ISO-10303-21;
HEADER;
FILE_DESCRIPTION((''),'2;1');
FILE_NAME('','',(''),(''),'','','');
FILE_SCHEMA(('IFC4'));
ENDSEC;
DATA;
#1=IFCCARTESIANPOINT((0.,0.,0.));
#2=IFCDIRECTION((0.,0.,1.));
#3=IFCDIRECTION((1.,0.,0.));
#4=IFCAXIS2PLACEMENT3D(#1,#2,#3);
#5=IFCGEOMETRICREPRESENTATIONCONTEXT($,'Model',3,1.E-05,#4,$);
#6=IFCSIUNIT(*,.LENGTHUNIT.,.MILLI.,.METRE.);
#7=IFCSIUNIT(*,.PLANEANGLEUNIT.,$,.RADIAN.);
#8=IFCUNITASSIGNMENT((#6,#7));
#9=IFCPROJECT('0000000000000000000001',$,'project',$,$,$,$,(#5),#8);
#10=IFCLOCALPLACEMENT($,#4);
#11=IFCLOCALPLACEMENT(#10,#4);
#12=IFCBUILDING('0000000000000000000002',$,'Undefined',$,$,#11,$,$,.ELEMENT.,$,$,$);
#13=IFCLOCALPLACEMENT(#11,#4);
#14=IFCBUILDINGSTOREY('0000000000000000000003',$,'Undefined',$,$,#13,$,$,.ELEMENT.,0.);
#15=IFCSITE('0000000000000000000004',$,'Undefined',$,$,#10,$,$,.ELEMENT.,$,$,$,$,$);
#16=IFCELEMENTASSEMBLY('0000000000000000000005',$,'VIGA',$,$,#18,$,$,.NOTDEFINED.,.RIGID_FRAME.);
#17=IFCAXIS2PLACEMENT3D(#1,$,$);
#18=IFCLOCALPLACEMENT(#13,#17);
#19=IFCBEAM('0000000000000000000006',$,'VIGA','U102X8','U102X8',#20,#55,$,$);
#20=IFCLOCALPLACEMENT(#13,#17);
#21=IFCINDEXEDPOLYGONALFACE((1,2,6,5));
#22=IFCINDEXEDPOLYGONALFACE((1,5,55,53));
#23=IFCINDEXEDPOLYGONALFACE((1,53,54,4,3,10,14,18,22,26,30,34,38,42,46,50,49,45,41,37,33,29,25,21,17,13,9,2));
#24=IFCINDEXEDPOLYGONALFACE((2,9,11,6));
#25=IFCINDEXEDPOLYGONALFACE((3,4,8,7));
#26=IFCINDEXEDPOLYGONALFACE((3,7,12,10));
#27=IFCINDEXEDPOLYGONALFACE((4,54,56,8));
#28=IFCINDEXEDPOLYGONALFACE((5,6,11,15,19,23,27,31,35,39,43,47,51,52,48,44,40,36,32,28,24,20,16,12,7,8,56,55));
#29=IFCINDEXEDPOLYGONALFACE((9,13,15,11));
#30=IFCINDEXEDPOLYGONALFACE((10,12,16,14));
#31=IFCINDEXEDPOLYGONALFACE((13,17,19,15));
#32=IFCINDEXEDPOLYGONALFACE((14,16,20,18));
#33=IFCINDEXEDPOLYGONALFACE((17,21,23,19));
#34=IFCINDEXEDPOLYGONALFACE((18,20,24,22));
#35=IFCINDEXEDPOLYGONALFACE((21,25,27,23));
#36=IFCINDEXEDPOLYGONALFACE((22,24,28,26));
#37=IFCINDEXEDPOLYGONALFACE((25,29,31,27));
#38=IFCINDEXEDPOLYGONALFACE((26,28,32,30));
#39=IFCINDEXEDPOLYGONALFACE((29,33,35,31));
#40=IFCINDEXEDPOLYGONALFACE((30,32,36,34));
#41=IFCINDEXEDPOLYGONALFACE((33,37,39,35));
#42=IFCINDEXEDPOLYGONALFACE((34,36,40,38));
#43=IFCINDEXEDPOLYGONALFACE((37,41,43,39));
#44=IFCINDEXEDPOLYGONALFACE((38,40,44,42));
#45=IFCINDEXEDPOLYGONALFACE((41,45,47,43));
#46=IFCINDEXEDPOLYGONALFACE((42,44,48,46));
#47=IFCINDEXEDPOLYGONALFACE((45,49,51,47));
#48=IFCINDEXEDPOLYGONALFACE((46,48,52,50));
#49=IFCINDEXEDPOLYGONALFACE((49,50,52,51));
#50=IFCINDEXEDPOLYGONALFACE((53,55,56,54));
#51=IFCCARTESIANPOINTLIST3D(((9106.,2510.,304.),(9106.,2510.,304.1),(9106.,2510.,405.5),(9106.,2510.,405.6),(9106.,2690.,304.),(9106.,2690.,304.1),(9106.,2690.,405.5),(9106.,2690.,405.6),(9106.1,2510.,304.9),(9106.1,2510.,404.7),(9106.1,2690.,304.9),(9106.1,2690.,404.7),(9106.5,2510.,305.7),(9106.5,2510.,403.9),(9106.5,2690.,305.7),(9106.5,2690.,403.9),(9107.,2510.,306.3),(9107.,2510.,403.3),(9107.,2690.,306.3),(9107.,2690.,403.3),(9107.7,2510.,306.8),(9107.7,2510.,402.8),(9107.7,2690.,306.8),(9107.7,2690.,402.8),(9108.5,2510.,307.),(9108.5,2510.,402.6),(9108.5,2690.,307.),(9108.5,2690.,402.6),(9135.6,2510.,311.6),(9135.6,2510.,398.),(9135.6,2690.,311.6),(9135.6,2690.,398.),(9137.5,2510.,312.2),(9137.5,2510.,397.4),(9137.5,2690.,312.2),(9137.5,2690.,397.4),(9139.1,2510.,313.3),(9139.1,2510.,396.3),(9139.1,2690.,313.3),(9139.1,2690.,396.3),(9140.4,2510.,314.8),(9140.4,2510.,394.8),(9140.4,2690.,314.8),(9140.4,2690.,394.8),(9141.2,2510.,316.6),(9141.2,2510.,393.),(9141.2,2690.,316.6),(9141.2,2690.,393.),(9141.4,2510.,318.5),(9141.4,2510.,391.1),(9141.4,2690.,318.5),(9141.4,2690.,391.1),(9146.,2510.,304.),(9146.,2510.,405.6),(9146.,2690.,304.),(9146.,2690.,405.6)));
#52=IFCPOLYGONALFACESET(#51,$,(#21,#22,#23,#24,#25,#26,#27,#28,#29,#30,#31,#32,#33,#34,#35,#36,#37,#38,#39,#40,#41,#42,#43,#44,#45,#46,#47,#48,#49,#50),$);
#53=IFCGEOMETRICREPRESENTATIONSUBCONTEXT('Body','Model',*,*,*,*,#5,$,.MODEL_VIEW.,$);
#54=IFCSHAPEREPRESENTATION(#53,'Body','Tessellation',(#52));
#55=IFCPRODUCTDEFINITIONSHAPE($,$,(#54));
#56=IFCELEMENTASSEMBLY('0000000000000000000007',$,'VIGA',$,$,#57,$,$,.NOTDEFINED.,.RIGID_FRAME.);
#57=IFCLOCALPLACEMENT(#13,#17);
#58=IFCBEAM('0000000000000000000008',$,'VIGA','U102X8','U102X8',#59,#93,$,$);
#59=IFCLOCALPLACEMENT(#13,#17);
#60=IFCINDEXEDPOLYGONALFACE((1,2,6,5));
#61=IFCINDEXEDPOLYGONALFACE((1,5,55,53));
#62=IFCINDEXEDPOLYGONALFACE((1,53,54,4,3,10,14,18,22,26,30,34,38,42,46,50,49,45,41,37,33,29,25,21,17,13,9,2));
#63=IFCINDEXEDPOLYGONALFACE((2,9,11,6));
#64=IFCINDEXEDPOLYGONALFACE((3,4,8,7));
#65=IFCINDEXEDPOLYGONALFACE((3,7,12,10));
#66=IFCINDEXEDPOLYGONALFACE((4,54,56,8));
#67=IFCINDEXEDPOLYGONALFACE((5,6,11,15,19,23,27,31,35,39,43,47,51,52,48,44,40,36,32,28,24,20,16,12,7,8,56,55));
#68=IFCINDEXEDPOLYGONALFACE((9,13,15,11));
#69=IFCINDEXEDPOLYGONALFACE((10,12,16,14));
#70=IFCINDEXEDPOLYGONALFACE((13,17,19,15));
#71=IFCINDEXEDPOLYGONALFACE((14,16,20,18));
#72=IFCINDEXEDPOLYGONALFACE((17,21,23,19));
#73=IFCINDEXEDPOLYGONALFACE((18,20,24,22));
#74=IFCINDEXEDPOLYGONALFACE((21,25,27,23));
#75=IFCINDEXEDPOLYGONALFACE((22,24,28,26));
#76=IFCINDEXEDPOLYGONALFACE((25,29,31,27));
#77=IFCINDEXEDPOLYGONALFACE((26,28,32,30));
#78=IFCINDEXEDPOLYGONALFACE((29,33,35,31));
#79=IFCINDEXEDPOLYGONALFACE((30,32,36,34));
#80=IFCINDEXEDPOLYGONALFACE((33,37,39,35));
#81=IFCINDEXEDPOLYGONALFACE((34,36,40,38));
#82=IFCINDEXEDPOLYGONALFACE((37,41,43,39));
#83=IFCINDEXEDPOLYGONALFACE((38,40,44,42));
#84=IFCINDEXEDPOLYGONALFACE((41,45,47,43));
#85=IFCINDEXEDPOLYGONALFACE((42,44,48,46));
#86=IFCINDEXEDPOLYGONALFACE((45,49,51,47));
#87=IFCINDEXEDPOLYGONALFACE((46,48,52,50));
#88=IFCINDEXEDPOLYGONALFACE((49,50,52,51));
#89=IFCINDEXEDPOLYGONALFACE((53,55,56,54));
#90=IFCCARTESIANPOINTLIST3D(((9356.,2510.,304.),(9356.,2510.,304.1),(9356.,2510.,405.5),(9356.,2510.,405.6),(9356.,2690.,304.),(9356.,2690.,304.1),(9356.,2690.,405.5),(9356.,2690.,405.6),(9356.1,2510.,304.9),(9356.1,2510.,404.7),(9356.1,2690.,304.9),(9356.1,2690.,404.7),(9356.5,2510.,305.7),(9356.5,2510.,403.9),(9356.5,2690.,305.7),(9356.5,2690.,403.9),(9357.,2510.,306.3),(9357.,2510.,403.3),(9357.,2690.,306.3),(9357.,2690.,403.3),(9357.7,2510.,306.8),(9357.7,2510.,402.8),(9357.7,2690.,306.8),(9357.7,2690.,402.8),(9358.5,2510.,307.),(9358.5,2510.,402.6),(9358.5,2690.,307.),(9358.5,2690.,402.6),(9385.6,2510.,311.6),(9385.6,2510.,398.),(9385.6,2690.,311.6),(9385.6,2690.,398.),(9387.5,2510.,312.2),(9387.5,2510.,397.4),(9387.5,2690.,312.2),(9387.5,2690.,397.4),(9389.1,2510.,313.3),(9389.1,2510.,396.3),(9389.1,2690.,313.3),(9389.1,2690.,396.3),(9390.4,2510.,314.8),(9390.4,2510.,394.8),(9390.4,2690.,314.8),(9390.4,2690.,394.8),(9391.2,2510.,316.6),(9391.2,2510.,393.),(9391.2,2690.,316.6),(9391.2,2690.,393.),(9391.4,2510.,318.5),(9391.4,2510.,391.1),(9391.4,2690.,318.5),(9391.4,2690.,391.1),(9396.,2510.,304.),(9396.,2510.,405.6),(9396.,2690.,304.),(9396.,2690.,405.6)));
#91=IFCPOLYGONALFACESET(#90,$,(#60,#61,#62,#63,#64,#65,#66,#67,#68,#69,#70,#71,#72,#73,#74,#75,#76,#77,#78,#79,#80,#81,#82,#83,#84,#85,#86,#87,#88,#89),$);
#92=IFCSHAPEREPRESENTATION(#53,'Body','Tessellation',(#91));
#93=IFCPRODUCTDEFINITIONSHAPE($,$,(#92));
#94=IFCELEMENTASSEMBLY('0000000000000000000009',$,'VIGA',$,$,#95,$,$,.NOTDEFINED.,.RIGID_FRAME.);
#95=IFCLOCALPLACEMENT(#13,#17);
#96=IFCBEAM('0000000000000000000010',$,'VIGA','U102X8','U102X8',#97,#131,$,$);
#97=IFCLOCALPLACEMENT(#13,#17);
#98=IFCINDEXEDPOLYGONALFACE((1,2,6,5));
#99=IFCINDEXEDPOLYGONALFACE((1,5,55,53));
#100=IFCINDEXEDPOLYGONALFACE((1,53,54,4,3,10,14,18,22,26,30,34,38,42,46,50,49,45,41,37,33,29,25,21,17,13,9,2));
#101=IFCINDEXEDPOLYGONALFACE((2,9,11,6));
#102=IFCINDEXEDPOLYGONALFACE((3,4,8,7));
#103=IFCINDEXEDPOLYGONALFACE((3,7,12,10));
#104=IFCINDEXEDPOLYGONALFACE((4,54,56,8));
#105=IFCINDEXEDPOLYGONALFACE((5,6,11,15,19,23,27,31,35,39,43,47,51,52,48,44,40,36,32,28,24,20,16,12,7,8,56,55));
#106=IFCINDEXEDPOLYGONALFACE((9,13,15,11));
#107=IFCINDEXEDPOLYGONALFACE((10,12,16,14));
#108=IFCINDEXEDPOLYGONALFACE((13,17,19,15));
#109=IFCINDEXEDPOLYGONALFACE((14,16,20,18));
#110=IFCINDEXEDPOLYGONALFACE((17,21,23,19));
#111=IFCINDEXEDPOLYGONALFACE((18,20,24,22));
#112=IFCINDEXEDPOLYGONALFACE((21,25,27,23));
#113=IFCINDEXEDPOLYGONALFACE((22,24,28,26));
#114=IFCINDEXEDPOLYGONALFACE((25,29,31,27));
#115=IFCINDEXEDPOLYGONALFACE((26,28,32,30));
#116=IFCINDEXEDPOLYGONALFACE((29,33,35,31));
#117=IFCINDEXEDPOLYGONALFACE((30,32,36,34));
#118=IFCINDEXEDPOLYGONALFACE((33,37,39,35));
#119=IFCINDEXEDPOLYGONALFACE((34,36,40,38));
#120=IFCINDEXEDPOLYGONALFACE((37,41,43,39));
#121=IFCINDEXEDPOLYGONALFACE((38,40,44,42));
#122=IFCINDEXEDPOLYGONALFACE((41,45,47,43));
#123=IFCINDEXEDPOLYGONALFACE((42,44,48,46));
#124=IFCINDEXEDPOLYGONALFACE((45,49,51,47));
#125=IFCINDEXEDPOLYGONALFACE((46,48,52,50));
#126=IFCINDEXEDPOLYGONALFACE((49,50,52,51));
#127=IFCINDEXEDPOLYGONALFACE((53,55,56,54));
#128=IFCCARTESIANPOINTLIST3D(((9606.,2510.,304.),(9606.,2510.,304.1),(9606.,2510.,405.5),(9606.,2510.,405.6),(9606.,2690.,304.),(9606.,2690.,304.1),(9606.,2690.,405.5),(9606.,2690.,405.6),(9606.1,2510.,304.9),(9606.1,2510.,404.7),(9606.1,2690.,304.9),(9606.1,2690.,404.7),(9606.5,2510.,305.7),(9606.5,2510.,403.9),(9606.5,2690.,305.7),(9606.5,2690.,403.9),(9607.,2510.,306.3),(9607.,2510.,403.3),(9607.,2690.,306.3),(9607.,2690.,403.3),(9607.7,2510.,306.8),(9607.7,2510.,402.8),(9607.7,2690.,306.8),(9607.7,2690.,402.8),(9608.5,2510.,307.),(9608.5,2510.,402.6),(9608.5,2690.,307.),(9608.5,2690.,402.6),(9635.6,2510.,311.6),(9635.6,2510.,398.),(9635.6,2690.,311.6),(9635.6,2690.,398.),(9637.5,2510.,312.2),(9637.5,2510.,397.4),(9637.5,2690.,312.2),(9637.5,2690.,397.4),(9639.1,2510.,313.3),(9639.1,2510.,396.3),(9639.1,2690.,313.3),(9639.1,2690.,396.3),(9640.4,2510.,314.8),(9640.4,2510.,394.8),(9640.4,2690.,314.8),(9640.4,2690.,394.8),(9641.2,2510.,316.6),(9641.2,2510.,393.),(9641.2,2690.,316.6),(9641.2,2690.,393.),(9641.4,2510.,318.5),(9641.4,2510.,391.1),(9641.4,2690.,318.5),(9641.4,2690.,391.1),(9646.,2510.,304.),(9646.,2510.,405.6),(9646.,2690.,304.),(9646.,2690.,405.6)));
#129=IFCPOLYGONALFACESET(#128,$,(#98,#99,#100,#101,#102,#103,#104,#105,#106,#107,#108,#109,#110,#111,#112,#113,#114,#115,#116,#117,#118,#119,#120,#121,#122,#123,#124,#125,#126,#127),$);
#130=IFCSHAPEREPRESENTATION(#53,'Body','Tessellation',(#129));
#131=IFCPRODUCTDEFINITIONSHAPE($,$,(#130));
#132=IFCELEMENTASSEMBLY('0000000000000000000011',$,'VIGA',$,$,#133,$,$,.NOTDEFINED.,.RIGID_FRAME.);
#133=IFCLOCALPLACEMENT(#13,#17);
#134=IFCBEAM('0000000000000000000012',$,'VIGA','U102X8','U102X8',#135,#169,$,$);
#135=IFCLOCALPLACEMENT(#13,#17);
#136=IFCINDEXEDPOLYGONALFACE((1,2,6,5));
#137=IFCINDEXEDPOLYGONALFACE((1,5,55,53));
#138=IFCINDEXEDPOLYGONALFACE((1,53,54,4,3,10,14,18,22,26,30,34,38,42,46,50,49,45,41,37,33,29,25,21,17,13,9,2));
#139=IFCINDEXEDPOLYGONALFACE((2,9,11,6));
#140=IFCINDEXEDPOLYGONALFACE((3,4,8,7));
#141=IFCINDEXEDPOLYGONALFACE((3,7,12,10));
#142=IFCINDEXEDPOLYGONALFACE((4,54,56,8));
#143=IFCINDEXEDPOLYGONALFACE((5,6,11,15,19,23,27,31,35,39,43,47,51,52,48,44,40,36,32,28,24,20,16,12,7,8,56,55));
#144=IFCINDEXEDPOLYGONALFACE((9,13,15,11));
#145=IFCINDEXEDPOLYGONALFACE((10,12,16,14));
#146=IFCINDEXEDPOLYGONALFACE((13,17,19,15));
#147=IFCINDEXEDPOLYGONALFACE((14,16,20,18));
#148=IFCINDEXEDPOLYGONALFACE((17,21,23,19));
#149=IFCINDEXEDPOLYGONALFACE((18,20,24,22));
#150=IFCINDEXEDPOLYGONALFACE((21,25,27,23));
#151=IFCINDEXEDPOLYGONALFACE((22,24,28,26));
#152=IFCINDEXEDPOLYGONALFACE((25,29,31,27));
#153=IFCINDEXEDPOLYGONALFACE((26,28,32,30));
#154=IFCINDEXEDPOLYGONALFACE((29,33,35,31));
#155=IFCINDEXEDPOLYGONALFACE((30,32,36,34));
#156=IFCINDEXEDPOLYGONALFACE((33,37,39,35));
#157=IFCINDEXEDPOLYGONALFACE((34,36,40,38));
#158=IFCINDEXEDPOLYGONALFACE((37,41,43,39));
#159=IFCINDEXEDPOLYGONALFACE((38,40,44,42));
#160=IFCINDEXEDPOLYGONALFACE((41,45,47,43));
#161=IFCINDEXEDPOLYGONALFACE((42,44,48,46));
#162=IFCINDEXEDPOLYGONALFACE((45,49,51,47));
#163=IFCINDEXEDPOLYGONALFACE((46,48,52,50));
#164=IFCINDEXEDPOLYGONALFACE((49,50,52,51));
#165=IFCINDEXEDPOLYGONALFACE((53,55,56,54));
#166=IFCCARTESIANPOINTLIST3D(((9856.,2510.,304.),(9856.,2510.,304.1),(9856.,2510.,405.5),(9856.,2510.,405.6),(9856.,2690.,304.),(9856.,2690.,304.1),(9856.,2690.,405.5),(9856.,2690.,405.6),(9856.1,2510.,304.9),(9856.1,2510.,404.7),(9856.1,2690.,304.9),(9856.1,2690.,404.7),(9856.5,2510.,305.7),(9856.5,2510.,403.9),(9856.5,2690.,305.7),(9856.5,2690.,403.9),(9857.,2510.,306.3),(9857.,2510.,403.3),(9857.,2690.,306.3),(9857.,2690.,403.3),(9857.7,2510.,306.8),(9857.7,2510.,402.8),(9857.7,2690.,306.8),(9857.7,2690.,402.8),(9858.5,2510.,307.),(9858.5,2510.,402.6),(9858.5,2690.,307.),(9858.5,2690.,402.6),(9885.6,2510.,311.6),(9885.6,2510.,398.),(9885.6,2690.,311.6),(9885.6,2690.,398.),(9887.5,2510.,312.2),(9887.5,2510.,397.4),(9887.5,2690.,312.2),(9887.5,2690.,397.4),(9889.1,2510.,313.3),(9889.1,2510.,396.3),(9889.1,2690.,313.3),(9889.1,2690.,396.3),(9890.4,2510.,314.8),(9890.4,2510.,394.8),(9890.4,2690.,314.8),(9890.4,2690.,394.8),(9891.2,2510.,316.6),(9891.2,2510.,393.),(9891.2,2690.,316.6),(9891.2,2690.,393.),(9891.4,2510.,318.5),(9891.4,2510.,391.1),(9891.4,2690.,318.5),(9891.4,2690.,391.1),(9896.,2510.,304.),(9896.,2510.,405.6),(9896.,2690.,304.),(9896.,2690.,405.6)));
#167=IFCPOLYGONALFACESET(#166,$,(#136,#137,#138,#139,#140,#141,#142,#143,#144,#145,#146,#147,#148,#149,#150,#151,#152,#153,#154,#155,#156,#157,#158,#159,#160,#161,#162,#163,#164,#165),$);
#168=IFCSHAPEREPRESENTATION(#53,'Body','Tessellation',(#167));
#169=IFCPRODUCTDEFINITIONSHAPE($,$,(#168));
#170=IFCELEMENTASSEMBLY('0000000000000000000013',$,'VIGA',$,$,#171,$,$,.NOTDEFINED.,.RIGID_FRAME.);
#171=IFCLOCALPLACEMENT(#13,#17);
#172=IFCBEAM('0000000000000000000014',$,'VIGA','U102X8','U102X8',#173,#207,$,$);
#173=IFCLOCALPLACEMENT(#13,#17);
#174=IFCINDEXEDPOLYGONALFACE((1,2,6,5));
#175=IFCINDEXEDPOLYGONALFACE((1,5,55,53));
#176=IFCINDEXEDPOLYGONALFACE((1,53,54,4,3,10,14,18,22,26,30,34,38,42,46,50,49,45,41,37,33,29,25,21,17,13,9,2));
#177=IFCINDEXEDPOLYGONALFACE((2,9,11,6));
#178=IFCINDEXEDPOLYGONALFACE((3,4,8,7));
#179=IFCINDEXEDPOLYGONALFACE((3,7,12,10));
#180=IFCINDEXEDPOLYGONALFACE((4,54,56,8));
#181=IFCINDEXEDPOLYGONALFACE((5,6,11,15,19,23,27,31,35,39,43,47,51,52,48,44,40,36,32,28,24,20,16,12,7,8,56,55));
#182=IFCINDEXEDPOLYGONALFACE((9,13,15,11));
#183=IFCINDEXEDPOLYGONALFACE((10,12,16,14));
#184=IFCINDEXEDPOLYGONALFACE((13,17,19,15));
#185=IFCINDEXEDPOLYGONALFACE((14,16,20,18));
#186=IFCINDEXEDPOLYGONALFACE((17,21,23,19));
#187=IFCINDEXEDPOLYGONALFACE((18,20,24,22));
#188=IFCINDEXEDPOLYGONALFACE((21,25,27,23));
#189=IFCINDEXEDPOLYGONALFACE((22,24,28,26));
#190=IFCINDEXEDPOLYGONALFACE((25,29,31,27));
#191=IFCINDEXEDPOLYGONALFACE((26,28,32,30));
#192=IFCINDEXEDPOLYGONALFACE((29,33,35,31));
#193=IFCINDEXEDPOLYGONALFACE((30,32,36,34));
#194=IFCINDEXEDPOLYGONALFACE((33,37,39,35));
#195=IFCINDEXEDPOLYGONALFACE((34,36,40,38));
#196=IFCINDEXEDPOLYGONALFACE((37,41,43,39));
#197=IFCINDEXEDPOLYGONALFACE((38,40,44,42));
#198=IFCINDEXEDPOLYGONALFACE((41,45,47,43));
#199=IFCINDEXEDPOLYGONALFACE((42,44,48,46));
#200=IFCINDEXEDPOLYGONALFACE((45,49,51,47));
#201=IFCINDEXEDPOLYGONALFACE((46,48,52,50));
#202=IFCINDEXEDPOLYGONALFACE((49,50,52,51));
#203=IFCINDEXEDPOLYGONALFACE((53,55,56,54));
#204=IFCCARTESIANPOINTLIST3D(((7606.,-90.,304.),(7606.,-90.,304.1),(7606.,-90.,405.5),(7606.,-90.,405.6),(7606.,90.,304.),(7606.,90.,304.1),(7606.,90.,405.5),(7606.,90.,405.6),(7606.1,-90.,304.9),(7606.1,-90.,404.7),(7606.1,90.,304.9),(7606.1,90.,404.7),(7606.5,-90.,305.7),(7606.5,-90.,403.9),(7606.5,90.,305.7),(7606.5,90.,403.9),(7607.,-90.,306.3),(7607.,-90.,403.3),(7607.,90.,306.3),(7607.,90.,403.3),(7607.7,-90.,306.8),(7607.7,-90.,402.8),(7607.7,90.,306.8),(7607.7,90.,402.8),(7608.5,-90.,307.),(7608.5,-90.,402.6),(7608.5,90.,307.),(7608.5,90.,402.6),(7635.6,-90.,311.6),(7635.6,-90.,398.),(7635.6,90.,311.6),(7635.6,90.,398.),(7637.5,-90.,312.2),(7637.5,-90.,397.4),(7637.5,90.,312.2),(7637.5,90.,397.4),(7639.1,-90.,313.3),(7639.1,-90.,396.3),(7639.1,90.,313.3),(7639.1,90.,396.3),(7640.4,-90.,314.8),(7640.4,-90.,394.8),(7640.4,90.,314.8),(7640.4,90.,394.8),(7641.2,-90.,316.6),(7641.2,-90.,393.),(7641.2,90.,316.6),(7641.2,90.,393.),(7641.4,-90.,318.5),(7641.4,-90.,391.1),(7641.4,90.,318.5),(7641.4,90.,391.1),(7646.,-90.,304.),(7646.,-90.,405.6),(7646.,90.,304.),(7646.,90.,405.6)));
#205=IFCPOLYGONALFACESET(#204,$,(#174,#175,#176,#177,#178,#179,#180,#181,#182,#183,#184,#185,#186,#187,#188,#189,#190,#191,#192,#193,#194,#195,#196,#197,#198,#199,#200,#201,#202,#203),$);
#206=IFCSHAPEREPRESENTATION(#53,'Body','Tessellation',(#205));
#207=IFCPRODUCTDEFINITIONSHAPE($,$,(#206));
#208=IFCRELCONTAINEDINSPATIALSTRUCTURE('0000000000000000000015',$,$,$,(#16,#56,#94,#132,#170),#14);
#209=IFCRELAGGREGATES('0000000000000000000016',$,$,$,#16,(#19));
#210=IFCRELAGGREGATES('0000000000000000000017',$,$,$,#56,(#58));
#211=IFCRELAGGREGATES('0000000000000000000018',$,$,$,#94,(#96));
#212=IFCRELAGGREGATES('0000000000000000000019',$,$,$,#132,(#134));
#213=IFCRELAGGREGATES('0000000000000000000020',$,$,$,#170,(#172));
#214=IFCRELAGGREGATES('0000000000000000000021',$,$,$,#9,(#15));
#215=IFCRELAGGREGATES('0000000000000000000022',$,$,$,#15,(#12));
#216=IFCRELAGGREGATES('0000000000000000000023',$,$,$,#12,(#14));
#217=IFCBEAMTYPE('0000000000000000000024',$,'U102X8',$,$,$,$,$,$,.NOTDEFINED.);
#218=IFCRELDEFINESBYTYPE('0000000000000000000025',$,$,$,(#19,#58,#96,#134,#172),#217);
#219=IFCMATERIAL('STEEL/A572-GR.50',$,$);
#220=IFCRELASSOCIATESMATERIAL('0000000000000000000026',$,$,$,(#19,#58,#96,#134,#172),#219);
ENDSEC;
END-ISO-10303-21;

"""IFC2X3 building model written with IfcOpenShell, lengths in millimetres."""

from ifc_helpers import new_model, si_unit, frame, origin_with_axes, origin_2d_with_axis, place, context, subcontext, project, spatial, u_section, extrude, material, type_object, element, aggregate, save


model = new_model("IFC2X3")

# Units and contexts
model_context = context("Model", 3, precision=1e-05, world=origin_with_axes())
body_context = subcontext(model_context, "Body", "Model", "MODEL_VIEW")
ifc_project = project(units=[si_unit("LENGTHUNIT", "METRE", prefix="MILLI"), si_unit("PLANEANGLEUNIT", "RADIAN")], contexts=[model_context])

# Site, building, storey
site_placement = place(None, origin_with_axes())
site = spatial("IfcSite", under=ifc_project, at=site_placement, Name="Undefined", CompositionType="ELEMENT")
building_placement = place(site_placement, origin_with_axes())
building = spatial("IfcBuilding", under=site, at=building_placement, Name="Undefined", CompositionType="ELEMENT")
storey_placement = place(building_placement, origin_with_axes())
storey = spatial("IfcBuildingStorey", under=building, at=storey_placement, Name="Undefined", CompositionType="ELEMENT", Elevation=0.0)

# Element assemblies, beams
ifc_material_1 = material(Name="STEEL/A572-GR.50")
beam_type_1 = type_object("IfcBeamType", Name="U102X8", PredefinedType="NOTDEFINED")
assembly_1_placement = place(storey_placement, origin_with_axes())
assembly_1 = element("IfcElementAssembly", 1, at=assembly_1_placement, inside=storey, Name="VIGA", AssemblyPlace="NOTDEFINED", PredefinedType="RIGID_FRAME")
beam_1_placement = place(assembly_1_placement, frame((9126.0, 2690.0, 354.8), z_axis=(0.0, 0.0, 1.0), x_axis=(0.0, -1.0, 0.0)))
beam_1 = element("IfcBeam", 2, at=beam_1_placement, type_object=beam_type_1, material=ifc_material_1, Name="VIGA", Description="U102X8", ObjectType="U102X8", context=body_context, shape_type="SweptSolid", body=[
    extrude(u_section(Depth=101.6, FlangeWidth=40.0, WebThickness=4.6, FlangeThickness=6.0, FilletRadius=7.0, EdgeRadius=3.0, FlangeSlope=0.16839, at=origin_2d_with_axis()), frame((180.0, 0.0, 0.0), z_axis=(-1.0, 0.0, 0.0), x_axis=(0.0, -1.0, 0.0)), (0.0, 0.0, 1.0), 180.0),
])
aggregate(assembly_1, [beam_1])
assembly_2_placement = place(storey_placement, origin_with_axes())
assembly_2 = element("IfcElementAssembly", 3, at=assembly_2_placement, inside=storey, Name="VIGA", AssemblyPlace="NOTDEFINED", PredefinedType="RIGID_FRAME")
beam_2_placement = place(assembly_2_placement, frame((9376.0, 2690.0, 354.8), z_axis=(0.0, 0.0, 1.0), x_axis=(0.0, -1.0, 0.0)))
beam_2 = element("IfcBeam", 4, at=beam_2_placement, type_object=beam_type_1, material=ifc_material_1, Name="VIGA", Description="U102X8", ObjectType="U102X8", context=body_context, shape_type="SweptSolid", body=[
    extrude(u_section(Depth=101.6, FlangeWidth=40.0, WebThickness=4.6, FlangeThickness=6.0, FilletRadius=7.0, EdgeRadius=3.0, FlangeSlope=0.16839, at=origin_2d_with_axis()), frame((180.0, 0.0, 0.0), z_axis=(-1.0, 0.0, 0.0), x_axis=(0.0, -1.0, 0.0)), (0.0, 0.0, 1.0), 180.0),
])
aggregate(assembly_2, [beam_2])
assembly_3_placement = place(storey_placement, origin_with_axes())
assembly_3 = element("IfcElementAssembly", 5, at=assembly_3_placement, inside=storey, Name="VIGA", AssemblyPlace="NOTDEFINED", PredefinedType="RIGID_FRAME")
beam_3_placement = place(assembly_3_placement, frame((9626.0, 2690.0, 354.8), z_axis=(0.0, 0.0, 1.0), x_axis=(0.0, -1.0, 0.0)))
beam_3 = element("IfcBeam", 6, at=beam_3_placement, type_object=beam_type_1, material=ifc_material_1, Name="VIGA", Description="U102X8", ObjectType="U102X8", context=body_context, shape_type="SweptSolid", body=[
    extrude(u_section(Depth=101.6, FlangeWidth=40.0, WebThickness=4.6, FlangeThickness=6.0, FilletRadius=7.0, EdgeRadius=3.0, FlangeSlope=0.16839, at=origin_2d_with_axis()), frame((180.0, 0.0, 0.0), z_axis=(-1.0, 0.0, 0.0), x_axis=(0.0, -1.0, 0.0)), (0.0, 0.0, 1.0), 180.0),
])
aggregate(assembly_3, [beam_3])
assembly_4_placement = place(storey_placement, origin_with_axes())
assembly_4 = element("IfcElementAssembly", 7, at=assembly_4_placement, inside=storey, Name="VIGA", AssemblyPlace="NOTDEFINED", PredefinedType="RIGID_FRAME")
beam_4_placement = place(assembly_4_placement, frame((9876.0, 2690.0, 354.8), z_axis=(0.0, 0.0, 1.0), x_axis=(0.0, -1.0, 0.0)))
beam_4 = element("IfcBeam", 8, at=beam_4_placement, type_object=beam_type_1, material=ifc_material_1, Name="VIGA", Description="U102X8", ObjectType="U102X8", context=body_context, shape_type="SweptSolid", body=[
    extrude(u_section(Depth=101.6, FlangeWidth=40.0, WebThickness=4.6, FlangeThickness=6.0, FilletRadius=7.0, EdgeRadius=3.0, FlangeSlope=0.16839, at=origin_2d_with_axis()), frame((180.0, 0.0, 0.0), z_axis=(-1.0, 0.0, 0.0), x_axis=(0.0, -1.0, 0.0)), (0.0, 0.0, 1.0), 180.0),
])
aggregate(assembly_4, [beam_4])
assembly_5_placement = place(storey_placement, origin_with_axes())
assembly_5 = element("IfcElementAssembly", 9, at=assembly_5_placement, inside=storey, Name="VIGA", AssemblyPlace="NOTDEFINED", PredefinedType="RIGID_FRAME")
beam_5_placement = place(assembly_5_placement, frame((7626.0, 90.0, 354.8), z_axis=(0.0, 0.0, 1.0), x_axis=(0.0, -1.0, 0.0)))
beam_5 = element("IfcBeam", 10, at=beam_5_placement, type_object=beam_type_1, material=ifc_material_1, Name="VIGA", Description="U102X8", ObjectType="U102X8", context=body_context, shape_type="SweptSolid", body=[
    extrude(u_section(Depth=101.6, FlangeWidth=40.0, WebThickness=4.6, FlangeThickness=6.0, FilletRadius=7.0, EdgeRadius=3.0, FlangeSlope=0.16839, at=origin_2d_with_axis()), frame((180.0, 0.0, 0.0), z_axis=(-1.0, 0.0, 0.0), x_axis=(0.0, -1.0, 0.0)), (0.0, 0.0, 1.0), 180.0),
])
aggregate(assembly_5, [beam_5])

save(model, "model.ifc")
